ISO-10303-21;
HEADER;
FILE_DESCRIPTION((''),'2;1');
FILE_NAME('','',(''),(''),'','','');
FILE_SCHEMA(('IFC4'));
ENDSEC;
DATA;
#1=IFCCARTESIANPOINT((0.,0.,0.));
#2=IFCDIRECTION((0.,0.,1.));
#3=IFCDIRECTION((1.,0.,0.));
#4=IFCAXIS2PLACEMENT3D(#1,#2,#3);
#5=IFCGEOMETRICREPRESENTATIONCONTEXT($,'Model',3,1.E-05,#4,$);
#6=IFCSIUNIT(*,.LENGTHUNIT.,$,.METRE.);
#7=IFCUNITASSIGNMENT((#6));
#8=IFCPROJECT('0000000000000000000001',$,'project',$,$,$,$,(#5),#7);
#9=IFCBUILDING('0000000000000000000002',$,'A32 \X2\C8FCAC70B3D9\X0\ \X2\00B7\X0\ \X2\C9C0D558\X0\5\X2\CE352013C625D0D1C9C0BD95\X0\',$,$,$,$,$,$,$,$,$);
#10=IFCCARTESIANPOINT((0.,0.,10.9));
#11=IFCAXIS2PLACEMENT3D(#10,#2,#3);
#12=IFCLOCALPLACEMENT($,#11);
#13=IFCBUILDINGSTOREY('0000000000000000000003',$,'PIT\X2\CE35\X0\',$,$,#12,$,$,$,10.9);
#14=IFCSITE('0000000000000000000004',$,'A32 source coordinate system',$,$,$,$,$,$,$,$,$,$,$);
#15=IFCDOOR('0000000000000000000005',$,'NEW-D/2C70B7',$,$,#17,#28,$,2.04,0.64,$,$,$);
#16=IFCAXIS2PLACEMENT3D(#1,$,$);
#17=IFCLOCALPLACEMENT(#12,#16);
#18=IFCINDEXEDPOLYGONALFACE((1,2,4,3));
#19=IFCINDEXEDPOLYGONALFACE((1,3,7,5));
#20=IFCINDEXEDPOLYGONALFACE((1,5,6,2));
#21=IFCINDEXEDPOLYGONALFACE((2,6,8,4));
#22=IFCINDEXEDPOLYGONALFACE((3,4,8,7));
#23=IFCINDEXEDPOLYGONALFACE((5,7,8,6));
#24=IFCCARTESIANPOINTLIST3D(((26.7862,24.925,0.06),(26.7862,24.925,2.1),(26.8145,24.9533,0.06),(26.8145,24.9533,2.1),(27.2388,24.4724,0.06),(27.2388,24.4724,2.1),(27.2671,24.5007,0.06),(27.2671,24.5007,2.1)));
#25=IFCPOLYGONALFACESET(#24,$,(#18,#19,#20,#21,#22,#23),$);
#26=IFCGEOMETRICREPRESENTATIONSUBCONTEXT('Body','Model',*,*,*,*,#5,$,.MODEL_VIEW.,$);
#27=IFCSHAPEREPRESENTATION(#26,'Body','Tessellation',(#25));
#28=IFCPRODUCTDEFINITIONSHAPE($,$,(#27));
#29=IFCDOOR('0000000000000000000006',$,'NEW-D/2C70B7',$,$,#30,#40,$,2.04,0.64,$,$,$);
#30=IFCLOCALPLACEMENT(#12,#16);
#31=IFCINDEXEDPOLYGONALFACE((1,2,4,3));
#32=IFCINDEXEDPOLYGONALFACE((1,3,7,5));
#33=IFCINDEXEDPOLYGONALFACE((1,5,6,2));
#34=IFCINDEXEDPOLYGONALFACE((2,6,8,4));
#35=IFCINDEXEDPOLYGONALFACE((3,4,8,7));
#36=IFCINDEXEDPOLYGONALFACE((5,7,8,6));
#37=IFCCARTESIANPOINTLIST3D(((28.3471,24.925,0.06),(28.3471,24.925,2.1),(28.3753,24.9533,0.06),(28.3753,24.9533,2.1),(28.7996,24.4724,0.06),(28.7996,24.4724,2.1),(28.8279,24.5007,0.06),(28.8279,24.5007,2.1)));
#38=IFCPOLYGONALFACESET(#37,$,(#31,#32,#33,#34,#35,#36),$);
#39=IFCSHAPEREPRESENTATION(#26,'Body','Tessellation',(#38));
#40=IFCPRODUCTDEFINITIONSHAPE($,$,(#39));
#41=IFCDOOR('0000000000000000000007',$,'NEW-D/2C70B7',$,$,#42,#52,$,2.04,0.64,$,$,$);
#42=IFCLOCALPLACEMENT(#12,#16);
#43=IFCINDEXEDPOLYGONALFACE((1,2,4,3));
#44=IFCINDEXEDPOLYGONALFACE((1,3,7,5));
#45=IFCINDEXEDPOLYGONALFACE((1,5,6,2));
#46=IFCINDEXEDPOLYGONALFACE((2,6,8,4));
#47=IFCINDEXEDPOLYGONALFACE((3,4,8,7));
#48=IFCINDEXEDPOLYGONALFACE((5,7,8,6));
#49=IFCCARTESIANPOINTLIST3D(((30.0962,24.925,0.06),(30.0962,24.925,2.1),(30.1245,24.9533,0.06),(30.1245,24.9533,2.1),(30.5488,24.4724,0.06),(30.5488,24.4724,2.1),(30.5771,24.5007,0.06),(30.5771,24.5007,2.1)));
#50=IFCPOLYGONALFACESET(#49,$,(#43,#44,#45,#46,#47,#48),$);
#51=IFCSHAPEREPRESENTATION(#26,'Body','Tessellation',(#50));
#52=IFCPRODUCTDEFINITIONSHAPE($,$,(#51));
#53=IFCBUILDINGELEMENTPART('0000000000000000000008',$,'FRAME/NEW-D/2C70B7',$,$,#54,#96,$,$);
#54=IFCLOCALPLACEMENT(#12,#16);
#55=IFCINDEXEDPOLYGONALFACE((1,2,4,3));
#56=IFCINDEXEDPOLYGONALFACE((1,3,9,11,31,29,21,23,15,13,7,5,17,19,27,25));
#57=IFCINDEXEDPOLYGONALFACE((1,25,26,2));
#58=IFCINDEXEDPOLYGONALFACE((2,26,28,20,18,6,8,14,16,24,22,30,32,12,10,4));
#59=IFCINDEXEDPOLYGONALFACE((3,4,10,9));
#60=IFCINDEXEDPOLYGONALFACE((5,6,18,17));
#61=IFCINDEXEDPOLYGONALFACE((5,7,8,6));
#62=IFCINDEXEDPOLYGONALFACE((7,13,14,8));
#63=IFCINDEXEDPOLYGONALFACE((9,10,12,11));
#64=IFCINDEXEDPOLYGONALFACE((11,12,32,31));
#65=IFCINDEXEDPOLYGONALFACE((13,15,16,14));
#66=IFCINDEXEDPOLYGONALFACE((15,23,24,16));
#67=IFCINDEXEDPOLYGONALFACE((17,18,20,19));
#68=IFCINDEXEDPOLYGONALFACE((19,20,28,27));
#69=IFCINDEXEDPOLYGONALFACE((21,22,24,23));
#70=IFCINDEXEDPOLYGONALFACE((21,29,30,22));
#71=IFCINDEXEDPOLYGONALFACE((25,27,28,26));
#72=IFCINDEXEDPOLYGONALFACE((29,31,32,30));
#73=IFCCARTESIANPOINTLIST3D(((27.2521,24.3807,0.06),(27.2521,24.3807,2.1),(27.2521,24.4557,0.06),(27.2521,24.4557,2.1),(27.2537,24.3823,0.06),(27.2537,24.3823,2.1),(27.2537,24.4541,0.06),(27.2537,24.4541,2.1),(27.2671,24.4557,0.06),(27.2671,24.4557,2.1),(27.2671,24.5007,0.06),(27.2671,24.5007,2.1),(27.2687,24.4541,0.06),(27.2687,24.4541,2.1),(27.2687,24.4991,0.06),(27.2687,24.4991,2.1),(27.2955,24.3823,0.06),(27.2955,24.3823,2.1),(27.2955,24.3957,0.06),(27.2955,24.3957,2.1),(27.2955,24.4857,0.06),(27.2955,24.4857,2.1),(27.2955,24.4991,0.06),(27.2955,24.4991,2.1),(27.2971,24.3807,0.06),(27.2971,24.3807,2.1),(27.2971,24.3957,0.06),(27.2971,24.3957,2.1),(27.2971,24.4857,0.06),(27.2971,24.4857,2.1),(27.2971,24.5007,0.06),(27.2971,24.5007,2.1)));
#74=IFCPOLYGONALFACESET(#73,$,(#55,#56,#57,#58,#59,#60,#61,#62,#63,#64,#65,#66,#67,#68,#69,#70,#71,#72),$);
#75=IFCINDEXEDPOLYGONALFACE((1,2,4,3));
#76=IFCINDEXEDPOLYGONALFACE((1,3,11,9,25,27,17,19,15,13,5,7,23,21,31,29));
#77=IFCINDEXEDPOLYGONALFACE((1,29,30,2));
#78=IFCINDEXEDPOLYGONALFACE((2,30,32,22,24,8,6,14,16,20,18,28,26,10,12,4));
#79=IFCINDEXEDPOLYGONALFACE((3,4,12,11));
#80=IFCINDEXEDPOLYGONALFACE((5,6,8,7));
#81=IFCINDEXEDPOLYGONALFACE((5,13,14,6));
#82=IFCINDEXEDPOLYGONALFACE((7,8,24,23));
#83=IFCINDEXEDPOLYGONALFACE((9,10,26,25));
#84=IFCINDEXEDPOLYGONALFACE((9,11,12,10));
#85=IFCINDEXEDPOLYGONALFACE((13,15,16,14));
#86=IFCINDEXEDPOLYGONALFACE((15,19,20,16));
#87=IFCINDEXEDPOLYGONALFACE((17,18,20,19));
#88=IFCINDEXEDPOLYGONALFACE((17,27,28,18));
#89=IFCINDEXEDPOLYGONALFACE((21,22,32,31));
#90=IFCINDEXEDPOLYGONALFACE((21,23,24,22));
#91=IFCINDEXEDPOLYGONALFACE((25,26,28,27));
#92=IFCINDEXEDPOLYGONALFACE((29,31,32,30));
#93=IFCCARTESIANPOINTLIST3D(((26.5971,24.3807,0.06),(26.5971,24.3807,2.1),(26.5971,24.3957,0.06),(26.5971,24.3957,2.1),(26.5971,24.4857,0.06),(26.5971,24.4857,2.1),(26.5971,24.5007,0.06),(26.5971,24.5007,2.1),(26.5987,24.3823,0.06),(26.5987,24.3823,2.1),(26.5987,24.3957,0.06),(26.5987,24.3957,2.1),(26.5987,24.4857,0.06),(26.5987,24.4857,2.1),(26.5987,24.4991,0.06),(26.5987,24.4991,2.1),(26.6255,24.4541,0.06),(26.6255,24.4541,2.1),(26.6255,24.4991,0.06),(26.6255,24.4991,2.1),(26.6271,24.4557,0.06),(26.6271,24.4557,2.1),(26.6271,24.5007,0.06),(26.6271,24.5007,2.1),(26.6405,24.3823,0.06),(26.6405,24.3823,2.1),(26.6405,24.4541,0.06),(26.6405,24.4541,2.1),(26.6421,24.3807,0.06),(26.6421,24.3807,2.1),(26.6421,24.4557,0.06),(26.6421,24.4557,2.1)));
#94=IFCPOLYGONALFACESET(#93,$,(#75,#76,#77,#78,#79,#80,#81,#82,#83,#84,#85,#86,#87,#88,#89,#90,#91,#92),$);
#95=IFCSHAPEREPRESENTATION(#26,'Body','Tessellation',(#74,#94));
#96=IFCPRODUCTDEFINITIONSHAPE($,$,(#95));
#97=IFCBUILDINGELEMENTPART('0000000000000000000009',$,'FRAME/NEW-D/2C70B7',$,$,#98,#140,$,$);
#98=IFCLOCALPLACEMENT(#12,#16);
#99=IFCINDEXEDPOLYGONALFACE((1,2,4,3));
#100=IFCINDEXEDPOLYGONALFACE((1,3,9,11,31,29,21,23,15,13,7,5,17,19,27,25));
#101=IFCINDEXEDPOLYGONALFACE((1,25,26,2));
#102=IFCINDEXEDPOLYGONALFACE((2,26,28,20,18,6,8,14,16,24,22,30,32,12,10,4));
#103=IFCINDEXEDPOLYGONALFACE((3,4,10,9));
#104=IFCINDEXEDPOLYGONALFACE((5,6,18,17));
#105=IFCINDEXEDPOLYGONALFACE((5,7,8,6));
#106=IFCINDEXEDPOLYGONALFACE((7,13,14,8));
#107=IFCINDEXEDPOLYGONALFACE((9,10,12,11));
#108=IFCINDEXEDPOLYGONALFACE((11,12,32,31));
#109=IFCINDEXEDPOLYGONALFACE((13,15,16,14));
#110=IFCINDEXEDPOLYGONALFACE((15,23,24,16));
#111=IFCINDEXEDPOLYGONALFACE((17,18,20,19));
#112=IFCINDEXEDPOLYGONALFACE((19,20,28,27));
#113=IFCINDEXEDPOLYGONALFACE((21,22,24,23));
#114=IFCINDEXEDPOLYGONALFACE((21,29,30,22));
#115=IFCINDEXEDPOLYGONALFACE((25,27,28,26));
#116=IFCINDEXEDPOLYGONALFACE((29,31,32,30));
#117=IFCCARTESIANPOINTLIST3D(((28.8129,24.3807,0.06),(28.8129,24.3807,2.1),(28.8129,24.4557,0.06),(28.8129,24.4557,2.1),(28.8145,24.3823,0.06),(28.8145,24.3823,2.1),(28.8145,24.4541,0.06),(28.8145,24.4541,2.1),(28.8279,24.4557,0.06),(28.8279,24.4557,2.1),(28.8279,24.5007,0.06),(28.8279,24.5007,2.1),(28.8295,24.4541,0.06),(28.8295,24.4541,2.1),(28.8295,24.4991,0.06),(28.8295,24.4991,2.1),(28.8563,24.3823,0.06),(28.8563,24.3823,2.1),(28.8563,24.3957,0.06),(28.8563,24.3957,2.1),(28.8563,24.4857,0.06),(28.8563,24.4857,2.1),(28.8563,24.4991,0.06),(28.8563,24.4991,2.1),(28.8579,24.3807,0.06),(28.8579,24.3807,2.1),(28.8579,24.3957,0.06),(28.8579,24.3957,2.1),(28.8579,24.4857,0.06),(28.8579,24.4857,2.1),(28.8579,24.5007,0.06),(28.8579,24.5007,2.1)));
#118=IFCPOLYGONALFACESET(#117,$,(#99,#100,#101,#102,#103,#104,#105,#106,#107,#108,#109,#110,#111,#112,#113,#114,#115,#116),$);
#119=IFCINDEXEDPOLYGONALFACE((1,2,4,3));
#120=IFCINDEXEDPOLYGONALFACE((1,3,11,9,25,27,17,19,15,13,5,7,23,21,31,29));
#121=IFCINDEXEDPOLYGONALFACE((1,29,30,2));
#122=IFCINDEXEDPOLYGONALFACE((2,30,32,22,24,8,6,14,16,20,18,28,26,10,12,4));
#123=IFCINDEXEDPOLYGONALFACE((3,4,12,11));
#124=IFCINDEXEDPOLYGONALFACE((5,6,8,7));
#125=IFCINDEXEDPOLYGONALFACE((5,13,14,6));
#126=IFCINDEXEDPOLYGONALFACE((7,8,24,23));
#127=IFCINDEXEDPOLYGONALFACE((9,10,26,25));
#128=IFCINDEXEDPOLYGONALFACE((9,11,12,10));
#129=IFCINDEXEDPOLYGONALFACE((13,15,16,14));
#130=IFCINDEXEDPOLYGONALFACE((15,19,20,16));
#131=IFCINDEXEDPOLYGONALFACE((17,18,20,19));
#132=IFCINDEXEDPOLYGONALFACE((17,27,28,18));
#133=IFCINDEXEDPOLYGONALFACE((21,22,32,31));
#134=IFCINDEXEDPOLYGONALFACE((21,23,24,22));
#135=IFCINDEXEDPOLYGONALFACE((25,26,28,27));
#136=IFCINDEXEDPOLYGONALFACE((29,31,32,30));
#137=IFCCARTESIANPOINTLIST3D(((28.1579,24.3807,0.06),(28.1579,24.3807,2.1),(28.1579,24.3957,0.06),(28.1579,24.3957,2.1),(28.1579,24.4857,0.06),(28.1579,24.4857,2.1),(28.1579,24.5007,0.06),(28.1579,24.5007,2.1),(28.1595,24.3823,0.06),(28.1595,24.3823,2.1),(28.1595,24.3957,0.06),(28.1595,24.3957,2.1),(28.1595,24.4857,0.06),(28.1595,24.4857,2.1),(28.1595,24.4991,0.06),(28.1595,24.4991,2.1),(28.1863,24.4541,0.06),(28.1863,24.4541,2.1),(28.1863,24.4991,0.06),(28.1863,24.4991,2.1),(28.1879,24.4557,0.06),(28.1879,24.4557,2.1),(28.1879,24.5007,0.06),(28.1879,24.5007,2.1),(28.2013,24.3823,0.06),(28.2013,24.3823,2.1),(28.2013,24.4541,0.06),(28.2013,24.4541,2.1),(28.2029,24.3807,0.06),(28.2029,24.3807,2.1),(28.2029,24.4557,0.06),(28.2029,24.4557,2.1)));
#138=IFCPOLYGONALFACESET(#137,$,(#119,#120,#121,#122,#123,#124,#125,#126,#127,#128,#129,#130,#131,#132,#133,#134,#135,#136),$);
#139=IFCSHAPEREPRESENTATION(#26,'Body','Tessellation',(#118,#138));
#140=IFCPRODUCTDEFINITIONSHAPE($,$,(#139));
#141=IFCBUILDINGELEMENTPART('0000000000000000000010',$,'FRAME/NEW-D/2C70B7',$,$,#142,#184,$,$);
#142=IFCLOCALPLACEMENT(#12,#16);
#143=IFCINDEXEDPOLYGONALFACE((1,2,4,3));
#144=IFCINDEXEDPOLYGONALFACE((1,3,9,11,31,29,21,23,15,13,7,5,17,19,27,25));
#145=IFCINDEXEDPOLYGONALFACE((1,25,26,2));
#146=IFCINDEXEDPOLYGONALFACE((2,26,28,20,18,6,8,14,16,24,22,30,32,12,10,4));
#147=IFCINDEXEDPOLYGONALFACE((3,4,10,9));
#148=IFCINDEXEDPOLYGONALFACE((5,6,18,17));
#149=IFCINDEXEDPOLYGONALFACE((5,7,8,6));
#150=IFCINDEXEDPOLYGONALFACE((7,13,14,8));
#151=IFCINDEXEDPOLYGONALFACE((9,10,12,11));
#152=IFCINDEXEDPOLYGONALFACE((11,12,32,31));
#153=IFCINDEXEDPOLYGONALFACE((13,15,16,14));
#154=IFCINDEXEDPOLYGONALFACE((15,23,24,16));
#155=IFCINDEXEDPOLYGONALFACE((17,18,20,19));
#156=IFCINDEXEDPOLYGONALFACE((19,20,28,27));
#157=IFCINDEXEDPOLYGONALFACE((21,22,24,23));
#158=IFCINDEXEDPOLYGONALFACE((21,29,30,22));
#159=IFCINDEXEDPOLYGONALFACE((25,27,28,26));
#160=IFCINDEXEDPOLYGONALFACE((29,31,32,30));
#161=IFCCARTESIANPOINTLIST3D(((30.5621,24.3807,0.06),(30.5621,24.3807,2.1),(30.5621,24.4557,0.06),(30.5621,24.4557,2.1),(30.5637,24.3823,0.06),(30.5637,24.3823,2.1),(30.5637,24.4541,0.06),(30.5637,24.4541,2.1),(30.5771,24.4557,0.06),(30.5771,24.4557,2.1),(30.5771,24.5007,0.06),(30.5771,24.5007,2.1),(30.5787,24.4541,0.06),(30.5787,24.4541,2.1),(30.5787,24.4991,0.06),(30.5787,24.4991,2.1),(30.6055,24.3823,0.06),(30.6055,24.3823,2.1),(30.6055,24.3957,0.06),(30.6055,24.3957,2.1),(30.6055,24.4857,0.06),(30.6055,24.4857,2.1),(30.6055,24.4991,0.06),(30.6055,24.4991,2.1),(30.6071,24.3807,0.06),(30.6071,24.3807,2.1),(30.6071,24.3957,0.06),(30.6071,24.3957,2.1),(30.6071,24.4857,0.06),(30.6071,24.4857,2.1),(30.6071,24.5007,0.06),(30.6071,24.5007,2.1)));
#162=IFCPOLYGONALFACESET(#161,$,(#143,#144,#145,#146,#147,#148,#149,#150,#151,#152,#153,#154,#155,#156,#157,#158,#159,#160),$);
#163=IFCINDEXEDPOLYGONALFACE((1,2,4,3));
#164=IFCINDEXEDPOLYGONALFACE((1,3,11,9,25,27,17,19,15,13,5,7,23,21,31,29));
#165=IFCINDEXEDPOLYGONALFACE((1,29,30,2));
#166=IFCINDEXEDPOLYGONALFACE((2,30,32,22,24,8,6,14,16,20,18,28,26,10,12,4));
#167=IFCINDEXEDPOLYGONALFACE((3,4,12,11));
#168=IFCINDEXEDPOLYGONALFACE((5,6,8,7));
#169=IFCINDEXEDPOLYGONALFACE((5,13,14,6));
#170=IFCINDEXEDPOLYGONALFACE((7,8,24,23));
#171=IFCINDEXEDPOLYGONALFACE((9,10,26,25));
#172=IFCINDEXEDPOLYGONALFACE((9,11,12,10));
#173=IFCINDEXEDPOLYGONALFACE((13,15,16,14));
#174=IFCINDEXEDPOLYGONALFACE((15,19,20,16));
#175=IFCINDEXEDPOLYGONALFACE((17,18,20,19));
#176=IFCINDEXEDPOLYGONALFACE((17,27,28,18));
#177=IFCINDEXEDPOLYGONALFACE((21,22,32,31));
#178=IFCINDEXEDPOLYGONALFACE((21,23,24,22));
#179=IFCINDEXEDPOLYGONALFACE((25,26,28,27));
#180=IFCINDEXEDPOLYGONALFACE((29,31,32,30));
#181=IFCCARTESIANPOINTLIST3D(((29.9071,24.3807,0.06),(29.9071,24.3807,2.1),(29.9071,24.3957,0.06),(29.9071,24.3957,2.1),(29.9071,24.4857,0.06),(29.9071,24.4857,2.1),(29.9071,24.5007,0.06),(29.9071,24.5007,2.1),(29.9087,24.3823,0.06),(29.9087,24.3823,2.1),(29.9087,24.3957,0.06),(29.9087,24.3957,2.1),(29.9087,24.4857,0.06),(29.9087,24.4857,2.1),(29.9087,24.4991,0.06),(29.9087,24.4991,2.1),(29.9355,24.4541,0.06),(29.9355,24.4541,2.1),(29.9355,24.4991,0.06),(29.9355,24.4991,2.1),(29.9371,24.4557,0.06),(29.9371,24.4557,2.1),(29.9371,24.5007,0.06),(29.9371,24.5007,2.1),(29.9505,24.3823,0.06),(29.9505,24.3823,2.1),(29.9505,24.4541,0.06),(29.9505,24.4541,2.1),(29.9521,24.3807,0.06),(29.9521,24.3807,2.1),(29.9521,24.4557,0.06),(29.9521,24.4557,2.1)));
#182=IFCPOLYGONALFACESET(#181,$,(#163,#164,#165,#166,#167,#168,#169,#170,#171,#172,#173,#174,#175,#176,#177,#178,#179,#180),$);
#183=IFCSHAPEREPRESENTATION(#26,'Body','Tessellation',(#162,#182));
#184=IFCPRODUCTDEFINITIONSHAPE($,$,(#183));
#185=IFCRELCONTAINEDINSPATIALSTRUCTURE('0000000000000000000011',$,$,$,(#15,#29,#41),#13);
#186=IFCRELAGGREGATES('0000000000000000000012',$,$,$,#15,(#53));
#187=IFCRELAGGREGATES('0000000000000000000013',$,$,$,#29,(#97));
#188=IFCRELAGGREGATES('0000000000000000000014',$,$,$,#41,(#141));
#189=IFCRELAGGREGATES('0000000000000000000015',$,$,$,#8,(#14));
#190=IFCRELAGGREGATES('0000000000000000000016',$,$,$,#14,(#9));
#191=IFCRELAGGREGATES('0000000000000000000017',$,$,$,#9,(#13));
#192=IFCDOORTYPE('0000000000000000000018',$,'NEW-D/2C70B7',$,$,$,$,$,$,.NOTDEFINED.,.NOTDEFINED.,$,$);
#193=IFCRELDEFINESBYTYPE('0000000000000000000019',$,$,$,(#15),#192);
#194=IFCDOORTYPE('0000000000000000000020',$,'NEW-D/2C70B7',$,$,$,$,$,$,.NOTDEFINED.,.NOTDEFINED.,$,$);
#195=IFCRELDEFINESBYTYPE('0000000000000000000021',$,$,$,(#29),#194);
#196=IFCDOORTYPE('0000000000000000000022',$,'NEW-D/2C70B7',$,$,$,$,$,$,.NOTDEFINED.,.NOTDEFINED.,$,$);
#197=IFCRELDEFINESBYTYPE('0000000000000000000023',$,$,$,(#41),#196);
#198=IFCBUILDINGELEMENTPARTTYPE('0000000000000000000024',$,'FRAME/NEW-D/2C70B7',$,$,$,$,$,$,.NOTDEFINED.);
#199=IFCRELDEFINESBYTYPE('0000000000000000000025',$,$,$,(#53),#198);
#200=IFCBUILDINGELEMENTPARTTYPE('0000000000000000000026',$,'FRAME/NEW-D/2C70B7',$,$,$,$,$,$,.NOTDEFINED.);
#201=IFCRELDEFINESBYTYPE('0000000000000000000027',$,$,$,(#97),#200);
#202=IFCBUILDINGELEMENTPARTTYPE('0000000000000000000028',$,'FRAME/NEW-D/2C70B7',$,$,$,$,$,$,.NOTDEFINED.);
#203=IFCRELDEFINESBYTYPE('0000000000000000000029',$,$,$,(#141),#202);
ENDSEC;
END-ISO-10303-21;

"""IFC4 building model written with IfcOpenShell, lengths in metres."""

from ifc_helpers import new_model, si_unit, frame, origin, origin_with_axes, place, context, subcontext, project, spatial, polyline, outline, extrude, source, transform, mapped, type_object, type_shapes, element, aggregate, save


model = new_model("IFC4")

# Units and contexts
model_context = context("Model", 3, precision=1e-05, world=origin_with_axes())
body_context = subcontext(model_context, "Body", "Model", "MODEL_VIEW")
ifc_project = project(units=[si_unit("LENGTHUNIT", "METRE")], contexts=[model_context])

# Site, building, storey
site = spatial("IfcSite", under=ifc_project, Name="A32 source coordinate system")
building = spatial("IfcBuilding", under=site, Name="A32 주거동 · 지하5층–옥탑지붕")
storey_placement = place(None, frame((0.0, 0.0, 10.9), z_axis=(0.0, 0.0, 1.0), x_axis=(1.0, 0.0, 0.0)))
storey = spatial("IfcBuildingStorey", under=building, at=storey_placement, Name="PIT층", Elevation=10.9)

# Doors
door_type_1 = type_object("IfcDoorType", Name="NEW-D/2C70B7", OperationType="NOTDEFINED", PredefinedType="NOTDEFINED")
shared_shape_1 = source(origin(), body_context, "Body", "SweptSolid", [
    extrude(outline(polyline([(27.2671, 24.5007), (27.2388, 24.4724), (26.7862, 24.925), (26.8145, 24.9533), (27.2671, 24.5007)])), frame((0.0, 0.0, 0.06)), (0.0, 0.0, 1.0), 2.04),
])
type_shapes(door_type_1, [shared_shape_1])
door_1_placement = place(storey_placement, origin_with_axes())
door_1 = element("IfcDoor", 1, at=door_1_placement, inside=storey, type_object=door_type_1, Name="NEW-D/2C70B7", OverallHeight=2.04, OverallWidth=0.64, context=body_context, shape_type="MappedRepresentation", body=[
    mapped(shared_shape_1, transform((0.0, 0.0, 0.0), scale=1.0)),
])
door_type_2 = type_object("IfcDoorType", Name="NEW-D/2C70B7", OperationType="NOTDEFINED", PredefinedType="NOTDEFINED")
shared_shape_2 = source(origin(), body_context, "Body", "SweptSolid", [
    extrude(outline(polyline([(28.8279, 24.5007), (28.7996, 24.4724), (28.3471, 24.925), (28.3753, 24.9533), (28.8279, 24.5007)])), frame((0.0, 0.0, 0.06)), (0.0, 0.0, 1.0), 2.04),
])
type_shapes(door_type_2, [shared_shape_2])
door_2_placement = place(storey_placement, origin_with_axes())
door_2 = element("IfcDoor", 2, at=door_2_placement, inside=storey, type_object=door_type_2, Name="NEW-D/2C70B7", OverallHeight=2.04, OverallWidth=0.64, context=body_context, shape_type="MappedRepresentation", body=[
    mapped(shared_shape_2, transform((0.0, 0.0, 0.0), scale=1.0)),
])
door_type_3 = type_object("IfcDoorType", Name="NEW-D/2C70B7", OperationType="NOTDEFINED", PredefinedType="NOTDEFINED")
shared_shape_3 = source(origin(), body_context, "Body", "SweptSolid", [
    extrude(outline(polyline([(30.5771, 24.5007), (30.5488, 24.4724), (30.0962, 24.925), (30.1245, 24.9533), (30.5771, 24.5007)])), frame((0.0, 0.0, 0.06)), (0.0, 0.0, 1.0), 2.04),
])
type_shapes(door_type_3, [shared_shape_3])
door_3_placement = place(storey_placement, origin_with_axes())
door_3 = element("IfcDoor", 3, at=door_3_placement, inside=storey, type_object=door_type_3, Name="NEW-D/2C70B7", OverallHeight=2.04, OverallWidth=0.64, context=body_context, shape_type="MappedRepresentation", body=[
    mapped(shared_shape_3, transform((0.0, 0.0, 0.0), scale=1.0)),
])

# Building element parts
building_element_part_type_1 = type_object("IfcBuildingElementPartType", Name="FRAME/NEW-D/2C70B7", PredefinedType="NOTDEFINED")
shared_shape_4 = source(origin(), body_context, "Body", "SweptSolid", [
    extrude(outline(polyline([(27.2687, 24.4991), (27.2687, 24.4541), (27.2537, 24.4541), (27.2537, 24.3823), (27.2955, 24.3823), (27.2955, 24.3957), (27.2971, 24.3957), (27.2971, 24.3807), (27.2521, 24.3807), (27.2521, 24.4557), (27.2671, 24.4557), (27.2671, 24.5007), (27.2971, 24.5007), (27.2971, 24.4857), (27.2955, 24.4857), (27.2955, 24.4991), (27.2687, 24.4991)])), frame((0.0, 0.0, 0.06)), (0.0, 0.0, 1.0), 2.04),
    extrude(outline(polyline([(26.5971, 24.5007), (26.6271, 24.5007), (26.6271, 24.4557), (26.6421, 24.4557), (26.6421, 24.3807), (26.5971, 24.3807), (26.5971, 24.3957), (26.5987, 24.3957), (26.5987, 24.3823), (26.6405, 24.3823), (26.6405, 24.4541), (26.6255, 24.4541), (26.6255, 24.4991), (26.5987, 24.4991), (26.5987, 24.4857), (26.5971, 24.4857), (26.5971, 24.5007)])), frame((0.0, 0.0, 0.06)), (0.0, 0.0, 1.0), 2.04),
])
type_shapes(building_element_part_type_1, [shared_shape_4])
building_element_part_1_placement = place(door_1_placement, origin_with_axes())
building_element_part_1 = element("IfcBuildingElementPart", 4, at=building_element_part_1_placement, type_object=building_element_part_type_1, Name="FRAME/NEW-D/2C70B7", context=body_context, shape_type="MappedRepresentation", body=[
    mapped(shared_shape_4, transform((0.0, 0.0, 0.0), scale=1.0)),
])
aggregate(door_1, [building_element_part_1])
building_element_part_type_2 = type_object("IfcBuildingElementPartType", Name="FRAME/NEW-D/2C70B7", PredefinedType="NOTDEFINED")
shared_shape_5 = source(origin(), body_context, "Body", "SweptSolid", [
    extrude(outline(polyline([(28.8295, 24.4991), (28.8295, 24.4541), (28.8145, 24.4541), (28.8145, 24.3823), (28.8563, 24.3823), (28.8563, 24.3957), (28.8579, 24.3957), (28.8579, 24.3807), (28.8129, 24.3807), (28.8129, 24.4557), (28.8279, 24.4557), (28.8279, 24.5007), (28.8579, 24.5007), (28.8579, 24.4857), (28.8563, 24.4857), (28.8563, 24.4991), (28.8295, 24.4991)])), frame((0.0, 0.0, 0.06)), (0.0, 0.0, 1.0), 2.04),
    extrude(outline(polyline([(28.1579, 24.5007), (28.1879, 24.5007), (28.1879, 24.4557), (28.2029, 24.4557), (28.2029, 24.3807), (28.1579, 24.3807), (28.1579, 24.3957), (28.1595, 24.3957), (28.1595, 24.3823), (28.2013, 24.3823), (28.2013, 24.4541), (28.1863, 24.4541), (28.1863, 24.4991), (28.1595, 24.4991), (28.1595, 24.4857), (28.1579, 24.4857), (28.1579, 24.5007)])), frame((0.0, 0.0, 0.06)), (0.0, 0.0, 1.0), 2.04),
])
type_shapes(building_element_part_type_2, [shared_shape_5])
building_element_part_2_placement = place(door_2_placement, origin_with_axes())
building_element_part_2 = element("IfcBuildingElementPart", 5, at=building_element_part_2_placement, type_object=building_element_part_type_2, Name="FRAME/NEW-D/2C70B7", context=body_context, shape_type="MappedRepresentation", body=[
    mapped(shared_shape_5, transform((0.0, 0.0, 0.0), scale=1.0)),
])
aggregate(door_2, [building_element_part_2])
building_element_part_type_3 = type_object("IfcBuildingElementPartType", Name="FRAME/NEW-D/2C70B7", PredefinedType="NOTDEFINED")
shared_shape_6 = source(origin(), body_context, "Body", "SweptSolid", [
    extrude(outline(polyline([(30.5787, 24.4991), (30.5787, 24.4541), (30.5637, 24.4541), (30.5637, 24.3823), (30.6055, 24.3823), (30.6055, 24.3957), (30.6071, 24.3957), (30.6071, 24.3807), (30.5621, 24.3807), (30.5621, 24.4557), (30.5771, 24.4557), (30.5771, 24.5007), (30.6071, 24.5007), (30.6071, 24.4857), (30.6055, 24.4857), (30.6055, 24.4991), (30.5787, 24.4991)])), frame((0.0, 0.0, 0.06)), (0.0, 0.0, 1.0), 2.04),
    extrude(outline(polyline([(29.9071, 24.5007), (29.9371, 24.5007), (29.9371, 24.4557), (29.9521, 24.4557), (29.9521, 24.3807), (29.9071, 24.3807), (29.9071, 24.3957), (29.9087, 24.3957), (29.9087, 24.3823), (29.9505, 24.3823), (29.9505, 24.4541), (29.9355, 24.4541), (29.9355, 24.4991), (29.9087, 24.4991), (29.9087, 24.4857), (29.9071, 24.4857), (29.9071, 24.5007)])), frame((0.0, 0.0, 0.06)), (0.0, 0.0, 1.0), 2.04),
])
type_shapes(building_element_part_type_3, [shared_shape_6])
building_element_part_3_placement = place(door_3_placement, origin_with_axes())
building_element_part_3 = element("IfcBuildingElementPart", 6, at=building_element_part_3_placement, type_object=building_element_part_type_3, Name="FRAME/NEW-D/2C70B7", context=body_context, shape_type="MappedRepresentation", body=[
    mapped(shared_shape_6, transform((0.0, 0.0, 0.0), scale=1.0)),
])
aggregate(door_3, [building_element_part_3])

save(model, "model.ifc")
